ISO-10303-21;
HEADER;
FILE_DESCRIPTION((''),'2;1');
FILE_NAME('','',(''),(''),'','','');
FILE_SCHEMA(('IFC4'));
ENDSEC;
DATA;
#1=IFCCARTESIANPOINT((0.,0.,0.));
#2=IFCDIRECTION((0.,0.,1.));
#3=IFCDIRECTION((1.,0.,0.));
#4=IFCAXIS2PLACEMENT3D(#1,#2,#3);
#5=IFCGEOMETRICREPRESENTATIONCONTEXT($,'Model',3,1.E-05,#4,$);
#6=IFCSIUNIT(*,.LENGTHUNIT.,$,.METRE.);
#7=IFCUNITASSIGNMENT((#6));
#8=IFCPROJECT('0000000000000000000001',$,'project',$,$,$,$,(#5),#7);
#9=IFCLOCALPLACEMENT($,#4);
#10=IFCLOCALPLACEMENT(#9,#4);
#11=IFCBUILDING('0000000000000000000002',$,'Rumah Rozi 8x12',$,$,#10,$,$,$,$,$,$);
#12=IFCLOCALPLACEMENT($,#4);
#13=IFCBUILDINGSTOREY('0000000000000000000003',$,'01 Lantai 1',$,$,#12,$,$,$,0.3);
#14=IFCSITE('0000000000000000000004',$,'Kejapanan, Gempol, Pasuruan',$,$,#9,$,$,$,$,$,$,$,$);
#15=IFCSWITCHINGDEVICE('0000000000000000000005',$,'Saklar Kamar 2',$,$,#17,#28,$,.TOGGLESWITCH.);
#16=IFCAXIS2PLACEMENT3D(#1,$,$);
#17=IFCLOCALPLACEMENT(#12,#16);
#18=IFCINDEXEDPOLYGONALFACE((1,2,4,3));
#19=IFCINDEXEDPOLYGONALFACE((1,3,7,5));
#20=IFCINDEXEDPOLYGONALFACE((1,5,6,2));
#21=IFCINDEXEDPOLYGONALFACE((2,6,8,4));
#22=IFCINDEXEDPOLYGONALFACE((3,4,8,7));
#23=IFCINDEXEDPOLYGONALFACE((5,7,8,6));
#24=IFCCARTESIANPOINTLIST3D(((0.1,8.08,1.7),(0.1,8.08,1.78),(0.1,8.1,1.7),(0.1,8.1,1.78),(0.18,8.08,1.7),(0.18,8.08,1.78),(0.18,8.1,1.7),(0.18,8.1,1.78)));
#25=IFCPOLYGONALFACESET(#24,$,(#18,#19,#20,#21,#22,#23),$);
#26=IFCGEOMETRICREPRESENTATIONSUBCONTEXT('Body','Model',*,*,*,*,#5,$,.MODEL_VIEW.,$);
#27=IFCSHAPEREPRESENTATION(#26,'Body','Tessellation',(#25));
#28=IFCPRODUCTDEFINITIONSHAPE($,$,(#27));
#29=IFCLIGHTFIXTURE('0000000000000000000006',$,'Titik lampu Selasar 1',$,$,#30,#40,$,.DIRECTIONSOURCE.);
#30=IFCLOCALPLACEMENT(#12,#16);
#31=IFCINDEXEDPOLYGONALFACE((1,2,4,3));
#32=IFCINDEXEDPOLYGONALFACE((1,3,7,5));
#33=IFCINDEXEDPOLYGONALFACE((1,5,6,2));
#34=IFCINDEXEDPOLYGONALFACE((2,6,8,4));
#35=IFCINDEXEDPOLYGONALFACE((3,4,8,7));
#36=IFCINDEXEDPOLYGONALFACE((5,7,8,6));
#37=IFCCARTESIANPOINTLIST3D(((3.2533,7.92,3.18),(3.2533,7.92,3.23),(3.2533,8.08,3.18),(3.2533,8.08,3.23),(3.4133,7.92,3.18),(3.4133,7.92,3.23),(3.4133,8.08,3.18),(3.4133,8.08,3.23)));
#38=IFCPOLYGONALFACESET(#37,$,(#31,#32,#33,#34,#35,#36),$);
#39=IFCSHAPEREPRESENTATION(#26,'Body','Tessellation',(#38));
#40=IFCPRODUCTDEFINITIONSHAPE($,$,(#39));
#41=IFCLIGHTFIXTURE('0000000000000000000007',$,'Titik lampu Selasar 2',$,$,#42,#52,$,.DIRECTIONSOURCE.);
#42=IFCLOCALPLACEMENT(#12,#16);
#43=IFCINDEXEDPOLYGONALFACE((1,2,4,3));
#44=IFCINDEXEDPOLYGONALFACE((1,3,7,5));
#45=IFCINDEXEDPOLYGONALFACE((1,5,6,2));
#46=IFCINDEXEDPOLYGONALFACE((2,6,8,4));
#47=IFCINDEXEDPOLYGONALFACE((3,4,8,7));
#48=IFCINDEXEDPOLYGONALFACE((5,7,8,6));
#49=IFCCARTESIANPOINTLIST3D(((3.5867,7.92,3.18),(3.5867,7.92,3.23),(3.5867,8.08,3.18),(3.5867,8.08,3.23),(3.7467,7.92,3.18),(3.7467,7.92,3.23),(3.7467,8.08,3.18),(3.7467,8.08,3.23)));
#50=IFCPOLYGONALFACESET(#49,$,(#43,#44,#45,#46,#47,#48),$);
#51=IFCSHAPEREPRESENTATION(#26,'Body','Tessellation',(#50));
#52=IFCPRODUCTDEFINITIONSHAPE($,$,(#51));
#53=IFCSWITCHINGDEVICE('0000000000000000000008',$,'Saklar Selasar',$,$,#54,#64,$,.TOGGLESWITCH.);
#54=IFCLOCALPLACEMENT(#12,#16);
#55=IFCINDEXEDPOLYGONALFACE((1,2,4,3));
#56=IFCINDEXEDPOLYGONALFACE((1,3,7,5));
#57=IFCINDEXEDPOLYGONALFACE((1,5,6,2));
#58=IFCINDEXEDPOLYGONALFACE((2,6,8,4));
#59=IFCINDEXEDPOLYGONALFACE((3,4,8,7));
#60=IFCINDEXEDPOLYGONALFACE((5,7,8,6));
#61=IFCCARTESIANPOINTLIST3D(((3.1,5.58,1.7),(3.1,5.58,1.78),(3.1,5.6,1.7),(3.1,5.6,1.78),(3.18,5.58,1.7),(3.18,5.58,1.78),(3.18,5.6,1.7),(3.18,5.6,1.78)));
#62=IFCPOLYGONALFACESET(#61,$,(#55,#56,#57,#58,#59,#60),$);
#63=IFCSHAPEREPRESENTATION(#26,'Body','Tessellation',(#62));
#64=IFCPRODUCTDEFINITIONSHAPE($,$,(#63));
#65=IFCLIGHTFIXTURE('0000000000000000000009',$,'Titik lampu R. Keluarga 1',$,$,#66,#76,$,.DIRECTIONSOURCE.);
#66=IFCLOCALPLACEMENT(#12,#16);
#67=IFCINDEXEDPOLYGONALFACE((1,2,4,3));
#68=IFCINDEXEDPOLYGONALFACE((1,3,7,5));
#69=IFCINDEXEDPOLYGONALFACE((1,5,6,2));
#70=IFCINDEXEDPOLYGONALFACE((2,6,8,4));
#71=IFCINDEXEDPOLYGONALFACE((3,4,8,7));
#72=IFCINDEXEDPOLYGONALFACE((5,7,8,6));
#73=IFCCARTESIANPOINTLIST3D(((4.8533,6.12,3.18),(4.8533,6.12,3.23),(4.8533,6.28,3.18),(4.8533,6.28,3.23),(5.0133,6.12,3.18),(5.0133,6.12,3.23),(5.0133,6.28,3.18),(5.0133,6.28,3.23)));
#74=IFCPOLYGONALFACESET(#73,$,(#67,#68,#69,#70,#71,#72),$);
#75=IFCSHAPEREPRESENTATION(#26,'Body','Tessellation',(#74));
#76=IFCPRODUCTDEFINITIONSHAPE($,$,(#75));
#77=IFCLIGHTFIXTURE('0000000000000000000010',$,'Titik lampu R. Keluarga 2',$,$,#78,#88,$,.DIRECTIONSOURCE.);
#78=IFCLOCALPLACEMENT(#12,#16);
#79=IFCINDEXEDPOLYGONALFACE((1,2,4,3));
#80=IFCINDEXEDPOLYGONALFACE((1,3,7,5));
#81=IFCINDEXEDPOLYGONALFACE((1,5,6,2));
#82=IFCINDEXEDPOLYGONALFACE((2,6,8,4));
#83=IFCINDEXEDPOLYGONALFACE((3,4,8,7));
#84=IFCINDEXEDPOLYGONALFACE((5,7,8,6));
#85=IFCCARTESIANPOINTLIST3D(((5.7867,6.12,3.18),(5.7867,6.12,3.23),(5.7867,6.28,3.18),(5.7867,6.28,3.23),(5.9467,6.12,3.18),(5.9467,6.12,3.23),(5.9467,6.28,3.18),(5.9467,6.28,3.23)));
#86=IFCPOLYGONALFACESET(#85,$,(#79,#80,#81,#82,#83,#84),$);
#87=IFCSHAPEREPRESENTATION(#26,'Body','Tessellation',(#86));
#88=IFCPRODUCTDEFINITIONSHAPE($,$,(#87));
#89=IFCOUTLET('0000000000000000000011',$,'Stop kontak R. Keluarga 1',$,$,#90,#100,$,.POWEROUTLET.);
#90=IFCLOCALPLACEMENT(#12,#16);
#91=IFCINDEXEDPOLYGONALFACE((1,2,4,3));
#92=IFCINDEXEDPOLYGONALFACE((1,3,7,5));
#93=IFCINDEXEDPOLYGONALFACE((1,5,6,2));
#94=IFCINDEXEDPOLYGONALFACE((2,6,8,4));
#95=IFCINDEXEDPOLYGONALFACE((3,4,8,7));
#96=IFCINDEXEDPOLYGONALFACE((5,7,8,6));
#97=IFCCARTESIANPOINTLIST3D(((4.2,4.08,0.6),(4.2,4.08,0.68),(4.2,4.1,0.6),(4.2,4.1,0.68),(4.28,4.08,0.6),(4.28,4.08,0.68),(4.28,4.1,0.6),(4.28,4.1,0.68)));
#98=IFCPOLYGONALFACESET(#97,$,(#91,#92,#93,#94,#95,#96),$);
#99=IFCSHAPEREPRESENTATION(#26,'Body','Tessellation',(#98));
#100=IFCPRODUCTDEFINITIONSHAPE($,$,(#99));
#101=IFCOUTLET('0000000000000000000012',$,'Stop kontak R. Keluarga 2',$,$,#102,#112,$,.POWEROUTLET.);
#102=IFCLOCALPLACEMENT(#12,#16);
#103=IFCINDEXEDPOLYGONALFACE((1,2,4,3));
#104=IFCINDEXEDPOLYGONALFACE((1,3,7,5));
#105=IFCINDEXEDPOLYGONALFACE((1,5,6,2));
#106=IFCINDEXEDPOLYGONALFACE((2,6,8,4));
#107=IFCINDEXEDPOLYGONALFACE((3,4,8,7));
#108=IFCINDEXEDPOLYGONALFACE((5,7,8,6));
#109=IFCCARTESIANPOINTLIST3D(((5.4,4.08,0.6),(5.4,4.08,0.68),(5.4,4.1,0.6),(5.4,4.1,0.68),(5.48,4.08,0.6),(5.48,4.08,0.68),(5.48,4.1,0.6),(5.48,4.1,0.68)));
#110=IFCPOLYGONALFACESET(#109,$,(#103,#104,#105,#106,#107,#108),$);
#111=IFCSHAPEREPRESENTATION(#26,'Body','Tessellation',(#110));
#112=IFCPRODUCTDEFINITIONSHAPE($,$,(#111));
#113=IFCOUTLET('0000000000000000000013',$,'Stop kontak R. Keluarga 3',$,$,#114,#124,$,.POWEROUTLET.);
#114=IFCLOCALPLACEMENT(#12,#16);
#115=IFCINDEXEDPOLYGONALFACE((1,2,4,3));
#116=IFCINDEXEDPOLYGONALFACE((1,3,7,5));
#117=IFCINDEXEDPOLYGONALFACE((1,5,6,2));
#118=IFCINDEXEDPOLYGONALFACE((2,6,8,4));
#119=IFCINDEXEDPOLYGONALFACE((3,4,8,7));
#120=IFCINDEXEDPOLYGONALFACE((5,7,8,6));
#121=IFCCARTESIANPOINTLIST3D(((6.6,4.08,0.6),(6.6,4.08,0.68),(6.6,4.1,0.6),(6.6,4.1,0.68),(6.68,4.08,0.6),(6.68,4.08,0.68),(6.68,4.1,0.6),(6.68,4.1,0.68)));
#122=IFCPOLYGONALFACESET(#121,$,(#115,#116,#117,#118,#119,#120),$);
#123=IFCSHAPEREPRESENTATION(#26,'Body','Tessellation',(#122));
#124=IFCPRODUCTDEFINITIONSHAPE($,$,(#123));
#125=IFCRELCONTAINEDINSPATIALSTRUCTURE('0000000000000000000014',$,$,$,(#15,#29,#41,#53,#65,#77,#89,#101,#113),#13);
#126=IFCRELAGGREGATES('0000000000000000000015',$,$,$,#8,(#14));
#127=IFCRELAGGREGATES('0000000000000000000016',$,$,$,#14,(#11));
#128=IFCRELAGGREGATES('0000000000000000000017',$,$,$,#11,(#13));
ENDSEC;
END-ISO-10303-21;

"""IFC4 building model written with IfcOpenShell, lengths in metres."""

from ifc_helpers import new_model, si_unit, frame, origin_with_axes, place, context, subcontext, project, spatial, line, indexed_curve, outline, extrude, element, save


model = new_model("IFC4")

# Units and contexts
model_context = context("Model", 3, precision=1e-05, world=origin_with_axes())
body_context = subcontext(model_context, "Body", "Model", "MODEL_VIEW")
ifc_project = project(units=[si_unit("LENGTHUNIT", "METRE")], contexts=[model_context])

# Site, building, storey
site_placement = place(None, origin_with_axes())
site = spatial("IfcSite", under=ifc_project, at=site_placement, Name="Kejapanan, Gempol, Pasuruan")
building_placement = place(site_placement, origin_with_axes())
building = spatial("IfcBuilding", under=site, at=building_placement, Name="Rumah Rozi 8x12")
storey_placement = place(None, origin_with_axes())
storey = spatial("IfcBuildingStorey", under=building, at=storey_placement, Name="01 Lantai 1", Elevation=0.3)

# Switching device
switching_device_1_placement = place(storey_placement, origin_with_axes())
element("IfcSwitchingDevice", 1, at=switching_device_1_placement, inside=storey, Name="Saklar Kamar 2", PredefinedType="TOGGLESWITCH", context=body_context, shape_type="SweptSolid", body=[
    extrude(outline(indexed_curve([(0.1, 8.08), (0.18, 8.08), (0.18, 8.1), (0.1, 8.1)], segments=[line(1, 2, 3, 4, 1)])), frame((0.0, 0.0, 1.7), z_axis=(0.0, 0.0, 1.0), x_axis=(1.0, 0.0, 0.0)), (0.0, 0.0, 1.0), 0.08),
])

# Light fixtures
light_fixture_1_placement = place(storey_placement, origin_with_axes())
element("IfcLightFixture", 2, at=light_fixture_1_placement, inside=storey, Name="Titik lampu Selasar 1", PredefinedType="DIRECTIONSOURCE", context=body_context, shape_type="SweptSolid", body=[
    extrude(outline(indexed_curve([(3.2533, 7.92), (3.4133, 7.92), (3.4133, 8.08), (3.2533, 8.08)], segments=[line(1, 2, 3, 4, 1)])), frame((0.0, 0.0, 3.18), z_axis=(0.0, 0.0, 1.0), x_axis=(1.0, 0.0, 0.0)), (0.0, 0.0, 1.0), 0.05),
])
light_fixture_2_placement = place(storey_placement, origin_with_axes())
element("IfcLightFixture", 3, at=light_fixture_2_placement, inside=storey, Name="Titik lampu Selasar 2", PredefinedType="DIRECTIONSOURCE", context=body_context, shape_type="SweptSolid", body=[
    extrude(outline(indexed_curve([(3.5867, 7.92), (3.7467, 7.92), (3.7467, 8.08), (3.5867, 8.08)], segments=[line(1, 2, 3, 4, 1)])), frame((0.0, 0.0, 3.18), z_axis=(0.0, 0.0, 1.0), x_axis=(1.0, 0.0, 0.0)), (0.0, 0.0, 1.0), 0.05),
])

# Switching device
switching_device_2_placement = place(storey_placement, origin_with_axes())
element("IfcSwitchingDevice", 4, at=switching_device_2_placement, inside=storey, Name="Saklar Selasar", PredefinedType="TOGGLESWITCH", context=body_context, shape_type="SweptSolid", body=[
    extrude(outline(indexed_curve([(3.1, 5.58), (3.18, 5.58), (3.18, 5.6), (3.1, 5.6)], segments=[line(1, 2, 3, 4, 1)])), frame((0.0, 0.0, 1.7), z_axis=(0.0, 0.0, 1.0), x_axis=(1.0, 0.0, 0.0)), (0.0, 0.0, 1.0), 0.08),
])

# Light fixtures
light_fixture_3_placement = place(storey_placement, origin_with_axes())
element("IfcLightFixture", 5, at=light_fixture_3_placement, inside=storey, Name="Titik lampu R. Keluarga 1", PredefinedType="DIRECTIONSOURCE", context=body_context, shape_type="SweptSolid", body=[
    extrude(outline(indexed_curve([(4.8533, 6.12), (5.0133, 6.12), (5.0133, 6.28), (4.8533, 6.28)], segments=[line(1, 2, 3, 4, 1)])), frame((0.0, 0.0, 3.18), z_axis=(0.0, 0.0, 1.0), x_axis=(1.0, 0.0, 0.0)), (0.0, 0.0, 1.0), 0.05),
])
light_fixture_4_placement = place(storey_placement, origin_with_axes())
element("IfcLightFixture", 6, at=light_fixture_4_placement, inside=storey, Name="Titik lampu R. Keluarga 2", PredefinedType="DIRECTIONSOURCE", context=body_context, shape_type="SweptSolid", body=[
    extrude(outline(indexed_curve([(5.7867, 6.12), (5.9467, 6.12), (5.9467, 6.28), (5.7867, 6.28)], segments=[line(1, 2, 3, 4, 1)])), frame((0.0, 0.0, 3.18), z_axis=(0.0, 0.0, 1.0), x_axis=(1.0, 0.0, 0.0)), (0.0, 0.0, 1.0), 0.05),
])

# Outlets
outlet_1_placement = place(storey_placement, origin_with_axes())
element("IfcOutlet", 7, at=outlet_1_placement, inside=storey, Name="Stop kontak R. Keluarga 1", PredefinedType="POWEROUTLET", context=body_context, shape_type="SweptSolid", body=[
    extrude(outline(indexed_curve([(4.2, 4.08), (4.28, 4.08), (4.28, 4.1), (4.2, 4.1)], segments=[line(1, 2, 3, 4, 1)])), frame((0.0, 0.0, 0.6), z_axis=(0.0, 0.0, 1.0), x_axis=(1.0, 0.0, 0.0)), (0.0, 0.0, 1.0), 0.08),
])
outlet_2_placement = place(storey_placement, origin_with_axes())
element("IfcOutlet", 8, at=outlet_2_placement, inside=storey, Name="Stop kontak R. Keluarga 2", PredefinedType="POWEROUTLET", context=body_context, shape_type="SweptSolid", body=[
    extrude(outline(indexed_curve([(5.4, 4.08), (5.48, 4.08), (5.48, 4.1), (5.4, 4.1)], segments=[line(1, 2, 3, 4, 1)])), frame((0.0, 0.0, 0.6), z_axis=(0.0, 0.0, 1.0), x_axis=(1.0, 0.0, 0.0)), (0.0, 0.0, 1.0), 0.08),
])
outlet_3_placement = place(storey_placement, origin_with_axes())
element("IfcOutlet", 9, at=outlet_3_placement, inside=storey, Name="Stop kontak R. Keluarga 3", PredefinedType="POWEROUTLET", context=body_context, shape_type="SweptSolid", body=[
    extrude(outline(indexed_curve([(6.6, 4.08), (6.68, 4.08), (6.68, 4.1), (6.6, 4.1)], segments=[line(1, 2, 3, 4, 1)])), frame((0.0, 0.0, 0.6), z_axis=(0.0, 0.0, 1.0), x_axis=(1.0, 0.0, 0.0)), (0.0, 0.0, 1.0), 0.08),
])

save(model, "model.ifc")
